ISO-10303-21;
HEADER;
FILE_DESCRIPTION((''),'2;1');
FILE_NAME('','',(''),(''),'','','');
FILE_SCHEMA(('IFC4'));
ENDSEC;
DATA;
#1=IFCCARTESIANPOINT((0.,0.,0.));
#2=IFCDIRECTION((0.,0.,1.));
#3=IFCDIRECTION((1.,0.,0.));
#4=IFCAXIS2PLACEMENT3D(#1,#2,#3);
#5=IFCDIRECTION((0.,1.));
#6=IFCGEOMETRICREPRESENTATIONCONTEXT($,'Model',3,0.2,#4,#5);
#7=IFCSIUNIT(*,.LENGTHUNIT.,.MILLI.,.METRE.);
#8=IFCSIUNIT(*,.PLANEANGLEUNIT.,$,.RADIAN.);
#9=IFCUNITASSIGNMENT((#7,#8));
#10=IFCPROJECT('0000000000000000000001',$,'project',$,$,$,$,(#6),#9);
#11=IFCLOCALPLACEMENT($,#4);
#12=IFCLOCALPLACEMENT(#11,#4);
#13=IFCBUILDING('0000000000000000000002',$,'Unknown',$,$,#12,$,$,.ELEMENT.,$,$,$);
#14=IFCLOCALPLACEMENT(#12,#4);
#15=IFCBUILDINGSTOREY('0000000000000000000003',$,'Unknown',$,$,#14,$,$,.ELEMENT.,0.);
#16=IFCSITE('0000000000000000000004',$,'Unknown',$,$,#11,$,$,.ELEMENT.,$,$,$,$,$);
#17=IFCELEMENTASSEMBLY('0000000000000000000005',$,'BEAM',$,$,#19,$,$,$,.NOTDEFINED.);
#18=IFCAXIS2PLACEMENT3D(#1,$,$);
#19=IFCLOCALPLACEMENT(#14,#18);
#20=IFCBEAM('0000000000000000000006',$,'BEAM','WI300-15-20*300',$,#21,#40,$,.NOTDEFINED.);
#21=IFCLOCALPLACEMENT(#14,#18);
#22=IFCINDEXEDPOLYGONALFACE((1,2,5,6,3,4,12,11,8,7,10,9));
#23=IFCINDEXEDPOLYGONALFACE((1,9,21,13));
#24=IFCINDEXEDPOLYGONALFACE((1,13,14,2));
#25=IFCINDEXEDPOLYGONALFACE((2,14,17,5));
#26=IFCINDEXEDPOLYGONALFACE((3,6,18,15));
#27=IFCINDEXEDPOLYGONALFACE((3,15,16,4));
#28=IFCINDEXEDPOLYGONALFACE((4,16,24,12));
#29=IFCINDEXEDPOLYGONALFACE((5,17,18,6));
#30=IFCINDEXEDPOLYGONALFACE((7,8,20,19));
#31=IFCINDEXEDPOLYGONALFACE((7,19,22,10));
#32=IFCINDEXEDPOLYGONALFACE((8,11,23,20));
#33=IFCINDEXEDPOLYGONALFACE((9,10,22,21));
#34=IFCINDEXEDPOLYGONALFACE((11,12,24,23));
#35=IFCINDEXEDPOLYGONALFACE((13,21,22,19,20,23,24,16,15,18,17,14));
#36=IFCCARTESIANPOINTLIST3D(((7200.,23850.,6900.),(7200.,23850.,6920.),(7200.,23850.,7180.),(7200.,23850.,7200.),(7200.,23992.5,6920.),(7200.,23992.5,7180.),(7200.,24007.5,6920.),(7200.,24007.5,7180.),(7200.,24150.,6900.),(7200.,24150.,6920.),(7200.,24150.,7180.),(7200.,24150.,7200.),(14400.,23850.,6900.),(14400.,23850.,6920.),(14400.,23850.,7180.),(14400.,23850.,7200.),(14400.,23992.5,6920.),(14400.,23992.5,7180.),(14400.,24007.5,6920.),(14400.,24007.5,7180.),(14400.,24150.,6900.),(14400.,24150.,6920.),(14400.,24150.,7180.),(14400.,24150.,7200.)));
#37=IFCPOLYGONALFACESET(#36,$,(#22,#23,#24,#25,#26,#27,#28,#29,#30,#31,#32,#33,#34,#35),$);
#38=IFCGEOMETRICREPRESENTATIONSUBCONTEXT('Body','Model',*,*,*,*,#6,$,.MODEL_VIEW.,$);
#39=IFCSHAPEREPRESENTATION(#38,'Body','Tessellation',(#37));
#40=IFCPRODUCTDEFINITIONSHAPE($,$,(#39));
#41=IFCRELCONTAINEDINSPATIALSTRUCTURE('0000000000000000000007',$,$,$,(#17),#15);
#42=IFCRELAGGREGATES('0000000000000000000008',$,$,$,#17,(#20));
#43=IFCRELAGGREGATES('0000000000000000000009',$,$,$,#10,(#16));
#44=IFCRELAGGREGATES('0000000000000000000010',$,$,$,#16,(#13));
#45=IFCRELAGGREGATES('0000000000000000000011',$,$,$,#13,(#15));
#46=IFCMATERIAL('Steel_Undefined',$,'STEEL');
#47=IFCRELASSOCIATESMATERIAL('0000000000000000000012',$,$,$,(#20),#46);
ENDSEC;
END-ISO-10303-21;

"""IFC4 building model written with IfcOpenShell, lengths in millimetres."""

from ifc_helpers import new_model, si_unit, direction, frame, origin_with_axes, place, context, subcontext, project, spatial, line, indexed_curve, outline, extrude, material, element, aggregate, save


model = new_model("IFC4")

# Units and contexts
model_context = context("Model", 3, precision=0.2, world=origin_with_axes(), true_north=direction((0.0, 1.0)))
body_context = subcontext(model_context, "Body", "Model", "MODEL_VIEW")
ifc_project = project(units=[si_unit("LENGTHUNIT", "METRE", prefix="MILLI"), si_unit("PLANEANGLEUNIT", "RADIAN")], contexts=[model_context])

# Site, building, storey
site_placement = place(None, origin_with_axes())
site = spatial("IfcSite", under=ifc_project, at=site_placement, Name="Unknown", CompositionType="ELEMENT")
building_placement = place(site_placement, origin_with_axes())
building = spatial("IfcBuilding", under=site, at=building_placement, Name="Unknown", CompositionType="ELEMENT")
storey_placement = place(building_placement, origin_with_axes())
storey = spatial("IfcBuildingStorey", under=building, at=storey_placement, Name="Unknown", CompositionType="ELEMENT", Elevation=0.0)

# Shared definitions
ifc_material = material(Name="Steel_Undefined", Category="STEEL")

# Element assembly, beam
assembly_1_placement = place(storey_placement, frame((14400.0, 24000.0, 7050.0), z_axis=(0.0, 1.0, 0.0), x_axis=(-1.0, 0.0, 0.0)))
assembly_1 = element("IfcElementAssembly", 1, at=assembly_1_placement, inside=storey, Name="BEAM", PredefinedType="NOTDEFINED")
beam_1_placement = place(assembly_1_placement, origin_with_axes())
beam_1 = element("IfcBeam", 2, at=beam_1_placement, material=ifc_material, Name="BEAM", Description="WI300-15-20*300", PredefinedType="NOTDEFINED", context=body_context, shape_type="SolidModel", body=[
    extrude(outline(indexed_curve([(-150.0, -150.0), (150.0, -150.0), (150.0, -130.0), (7.5, -130.0), (7.5, 130.0), (150.0, 130.0), (150.0, 150.0), (-150.0, 150.0), (-150.0, 130.0), (-7.5, 130.0), (-7.5, -130.0), (-150.0, -130.0)], segments=[line(1, 2, 3, 4, 5, 6, 7, 8, 9, 10, 11, 12, 1)])), frame((0.0, 0.0, 0.0), z_axis=(-1.0, 0.0, 0.0), x_axis=(0.0, 0.0, 1.0)), (0.0, 0.0, -1.0), 7200.0),
])
aggregate(assembly_1, [beam_1])

save(model, "model.ifc")
